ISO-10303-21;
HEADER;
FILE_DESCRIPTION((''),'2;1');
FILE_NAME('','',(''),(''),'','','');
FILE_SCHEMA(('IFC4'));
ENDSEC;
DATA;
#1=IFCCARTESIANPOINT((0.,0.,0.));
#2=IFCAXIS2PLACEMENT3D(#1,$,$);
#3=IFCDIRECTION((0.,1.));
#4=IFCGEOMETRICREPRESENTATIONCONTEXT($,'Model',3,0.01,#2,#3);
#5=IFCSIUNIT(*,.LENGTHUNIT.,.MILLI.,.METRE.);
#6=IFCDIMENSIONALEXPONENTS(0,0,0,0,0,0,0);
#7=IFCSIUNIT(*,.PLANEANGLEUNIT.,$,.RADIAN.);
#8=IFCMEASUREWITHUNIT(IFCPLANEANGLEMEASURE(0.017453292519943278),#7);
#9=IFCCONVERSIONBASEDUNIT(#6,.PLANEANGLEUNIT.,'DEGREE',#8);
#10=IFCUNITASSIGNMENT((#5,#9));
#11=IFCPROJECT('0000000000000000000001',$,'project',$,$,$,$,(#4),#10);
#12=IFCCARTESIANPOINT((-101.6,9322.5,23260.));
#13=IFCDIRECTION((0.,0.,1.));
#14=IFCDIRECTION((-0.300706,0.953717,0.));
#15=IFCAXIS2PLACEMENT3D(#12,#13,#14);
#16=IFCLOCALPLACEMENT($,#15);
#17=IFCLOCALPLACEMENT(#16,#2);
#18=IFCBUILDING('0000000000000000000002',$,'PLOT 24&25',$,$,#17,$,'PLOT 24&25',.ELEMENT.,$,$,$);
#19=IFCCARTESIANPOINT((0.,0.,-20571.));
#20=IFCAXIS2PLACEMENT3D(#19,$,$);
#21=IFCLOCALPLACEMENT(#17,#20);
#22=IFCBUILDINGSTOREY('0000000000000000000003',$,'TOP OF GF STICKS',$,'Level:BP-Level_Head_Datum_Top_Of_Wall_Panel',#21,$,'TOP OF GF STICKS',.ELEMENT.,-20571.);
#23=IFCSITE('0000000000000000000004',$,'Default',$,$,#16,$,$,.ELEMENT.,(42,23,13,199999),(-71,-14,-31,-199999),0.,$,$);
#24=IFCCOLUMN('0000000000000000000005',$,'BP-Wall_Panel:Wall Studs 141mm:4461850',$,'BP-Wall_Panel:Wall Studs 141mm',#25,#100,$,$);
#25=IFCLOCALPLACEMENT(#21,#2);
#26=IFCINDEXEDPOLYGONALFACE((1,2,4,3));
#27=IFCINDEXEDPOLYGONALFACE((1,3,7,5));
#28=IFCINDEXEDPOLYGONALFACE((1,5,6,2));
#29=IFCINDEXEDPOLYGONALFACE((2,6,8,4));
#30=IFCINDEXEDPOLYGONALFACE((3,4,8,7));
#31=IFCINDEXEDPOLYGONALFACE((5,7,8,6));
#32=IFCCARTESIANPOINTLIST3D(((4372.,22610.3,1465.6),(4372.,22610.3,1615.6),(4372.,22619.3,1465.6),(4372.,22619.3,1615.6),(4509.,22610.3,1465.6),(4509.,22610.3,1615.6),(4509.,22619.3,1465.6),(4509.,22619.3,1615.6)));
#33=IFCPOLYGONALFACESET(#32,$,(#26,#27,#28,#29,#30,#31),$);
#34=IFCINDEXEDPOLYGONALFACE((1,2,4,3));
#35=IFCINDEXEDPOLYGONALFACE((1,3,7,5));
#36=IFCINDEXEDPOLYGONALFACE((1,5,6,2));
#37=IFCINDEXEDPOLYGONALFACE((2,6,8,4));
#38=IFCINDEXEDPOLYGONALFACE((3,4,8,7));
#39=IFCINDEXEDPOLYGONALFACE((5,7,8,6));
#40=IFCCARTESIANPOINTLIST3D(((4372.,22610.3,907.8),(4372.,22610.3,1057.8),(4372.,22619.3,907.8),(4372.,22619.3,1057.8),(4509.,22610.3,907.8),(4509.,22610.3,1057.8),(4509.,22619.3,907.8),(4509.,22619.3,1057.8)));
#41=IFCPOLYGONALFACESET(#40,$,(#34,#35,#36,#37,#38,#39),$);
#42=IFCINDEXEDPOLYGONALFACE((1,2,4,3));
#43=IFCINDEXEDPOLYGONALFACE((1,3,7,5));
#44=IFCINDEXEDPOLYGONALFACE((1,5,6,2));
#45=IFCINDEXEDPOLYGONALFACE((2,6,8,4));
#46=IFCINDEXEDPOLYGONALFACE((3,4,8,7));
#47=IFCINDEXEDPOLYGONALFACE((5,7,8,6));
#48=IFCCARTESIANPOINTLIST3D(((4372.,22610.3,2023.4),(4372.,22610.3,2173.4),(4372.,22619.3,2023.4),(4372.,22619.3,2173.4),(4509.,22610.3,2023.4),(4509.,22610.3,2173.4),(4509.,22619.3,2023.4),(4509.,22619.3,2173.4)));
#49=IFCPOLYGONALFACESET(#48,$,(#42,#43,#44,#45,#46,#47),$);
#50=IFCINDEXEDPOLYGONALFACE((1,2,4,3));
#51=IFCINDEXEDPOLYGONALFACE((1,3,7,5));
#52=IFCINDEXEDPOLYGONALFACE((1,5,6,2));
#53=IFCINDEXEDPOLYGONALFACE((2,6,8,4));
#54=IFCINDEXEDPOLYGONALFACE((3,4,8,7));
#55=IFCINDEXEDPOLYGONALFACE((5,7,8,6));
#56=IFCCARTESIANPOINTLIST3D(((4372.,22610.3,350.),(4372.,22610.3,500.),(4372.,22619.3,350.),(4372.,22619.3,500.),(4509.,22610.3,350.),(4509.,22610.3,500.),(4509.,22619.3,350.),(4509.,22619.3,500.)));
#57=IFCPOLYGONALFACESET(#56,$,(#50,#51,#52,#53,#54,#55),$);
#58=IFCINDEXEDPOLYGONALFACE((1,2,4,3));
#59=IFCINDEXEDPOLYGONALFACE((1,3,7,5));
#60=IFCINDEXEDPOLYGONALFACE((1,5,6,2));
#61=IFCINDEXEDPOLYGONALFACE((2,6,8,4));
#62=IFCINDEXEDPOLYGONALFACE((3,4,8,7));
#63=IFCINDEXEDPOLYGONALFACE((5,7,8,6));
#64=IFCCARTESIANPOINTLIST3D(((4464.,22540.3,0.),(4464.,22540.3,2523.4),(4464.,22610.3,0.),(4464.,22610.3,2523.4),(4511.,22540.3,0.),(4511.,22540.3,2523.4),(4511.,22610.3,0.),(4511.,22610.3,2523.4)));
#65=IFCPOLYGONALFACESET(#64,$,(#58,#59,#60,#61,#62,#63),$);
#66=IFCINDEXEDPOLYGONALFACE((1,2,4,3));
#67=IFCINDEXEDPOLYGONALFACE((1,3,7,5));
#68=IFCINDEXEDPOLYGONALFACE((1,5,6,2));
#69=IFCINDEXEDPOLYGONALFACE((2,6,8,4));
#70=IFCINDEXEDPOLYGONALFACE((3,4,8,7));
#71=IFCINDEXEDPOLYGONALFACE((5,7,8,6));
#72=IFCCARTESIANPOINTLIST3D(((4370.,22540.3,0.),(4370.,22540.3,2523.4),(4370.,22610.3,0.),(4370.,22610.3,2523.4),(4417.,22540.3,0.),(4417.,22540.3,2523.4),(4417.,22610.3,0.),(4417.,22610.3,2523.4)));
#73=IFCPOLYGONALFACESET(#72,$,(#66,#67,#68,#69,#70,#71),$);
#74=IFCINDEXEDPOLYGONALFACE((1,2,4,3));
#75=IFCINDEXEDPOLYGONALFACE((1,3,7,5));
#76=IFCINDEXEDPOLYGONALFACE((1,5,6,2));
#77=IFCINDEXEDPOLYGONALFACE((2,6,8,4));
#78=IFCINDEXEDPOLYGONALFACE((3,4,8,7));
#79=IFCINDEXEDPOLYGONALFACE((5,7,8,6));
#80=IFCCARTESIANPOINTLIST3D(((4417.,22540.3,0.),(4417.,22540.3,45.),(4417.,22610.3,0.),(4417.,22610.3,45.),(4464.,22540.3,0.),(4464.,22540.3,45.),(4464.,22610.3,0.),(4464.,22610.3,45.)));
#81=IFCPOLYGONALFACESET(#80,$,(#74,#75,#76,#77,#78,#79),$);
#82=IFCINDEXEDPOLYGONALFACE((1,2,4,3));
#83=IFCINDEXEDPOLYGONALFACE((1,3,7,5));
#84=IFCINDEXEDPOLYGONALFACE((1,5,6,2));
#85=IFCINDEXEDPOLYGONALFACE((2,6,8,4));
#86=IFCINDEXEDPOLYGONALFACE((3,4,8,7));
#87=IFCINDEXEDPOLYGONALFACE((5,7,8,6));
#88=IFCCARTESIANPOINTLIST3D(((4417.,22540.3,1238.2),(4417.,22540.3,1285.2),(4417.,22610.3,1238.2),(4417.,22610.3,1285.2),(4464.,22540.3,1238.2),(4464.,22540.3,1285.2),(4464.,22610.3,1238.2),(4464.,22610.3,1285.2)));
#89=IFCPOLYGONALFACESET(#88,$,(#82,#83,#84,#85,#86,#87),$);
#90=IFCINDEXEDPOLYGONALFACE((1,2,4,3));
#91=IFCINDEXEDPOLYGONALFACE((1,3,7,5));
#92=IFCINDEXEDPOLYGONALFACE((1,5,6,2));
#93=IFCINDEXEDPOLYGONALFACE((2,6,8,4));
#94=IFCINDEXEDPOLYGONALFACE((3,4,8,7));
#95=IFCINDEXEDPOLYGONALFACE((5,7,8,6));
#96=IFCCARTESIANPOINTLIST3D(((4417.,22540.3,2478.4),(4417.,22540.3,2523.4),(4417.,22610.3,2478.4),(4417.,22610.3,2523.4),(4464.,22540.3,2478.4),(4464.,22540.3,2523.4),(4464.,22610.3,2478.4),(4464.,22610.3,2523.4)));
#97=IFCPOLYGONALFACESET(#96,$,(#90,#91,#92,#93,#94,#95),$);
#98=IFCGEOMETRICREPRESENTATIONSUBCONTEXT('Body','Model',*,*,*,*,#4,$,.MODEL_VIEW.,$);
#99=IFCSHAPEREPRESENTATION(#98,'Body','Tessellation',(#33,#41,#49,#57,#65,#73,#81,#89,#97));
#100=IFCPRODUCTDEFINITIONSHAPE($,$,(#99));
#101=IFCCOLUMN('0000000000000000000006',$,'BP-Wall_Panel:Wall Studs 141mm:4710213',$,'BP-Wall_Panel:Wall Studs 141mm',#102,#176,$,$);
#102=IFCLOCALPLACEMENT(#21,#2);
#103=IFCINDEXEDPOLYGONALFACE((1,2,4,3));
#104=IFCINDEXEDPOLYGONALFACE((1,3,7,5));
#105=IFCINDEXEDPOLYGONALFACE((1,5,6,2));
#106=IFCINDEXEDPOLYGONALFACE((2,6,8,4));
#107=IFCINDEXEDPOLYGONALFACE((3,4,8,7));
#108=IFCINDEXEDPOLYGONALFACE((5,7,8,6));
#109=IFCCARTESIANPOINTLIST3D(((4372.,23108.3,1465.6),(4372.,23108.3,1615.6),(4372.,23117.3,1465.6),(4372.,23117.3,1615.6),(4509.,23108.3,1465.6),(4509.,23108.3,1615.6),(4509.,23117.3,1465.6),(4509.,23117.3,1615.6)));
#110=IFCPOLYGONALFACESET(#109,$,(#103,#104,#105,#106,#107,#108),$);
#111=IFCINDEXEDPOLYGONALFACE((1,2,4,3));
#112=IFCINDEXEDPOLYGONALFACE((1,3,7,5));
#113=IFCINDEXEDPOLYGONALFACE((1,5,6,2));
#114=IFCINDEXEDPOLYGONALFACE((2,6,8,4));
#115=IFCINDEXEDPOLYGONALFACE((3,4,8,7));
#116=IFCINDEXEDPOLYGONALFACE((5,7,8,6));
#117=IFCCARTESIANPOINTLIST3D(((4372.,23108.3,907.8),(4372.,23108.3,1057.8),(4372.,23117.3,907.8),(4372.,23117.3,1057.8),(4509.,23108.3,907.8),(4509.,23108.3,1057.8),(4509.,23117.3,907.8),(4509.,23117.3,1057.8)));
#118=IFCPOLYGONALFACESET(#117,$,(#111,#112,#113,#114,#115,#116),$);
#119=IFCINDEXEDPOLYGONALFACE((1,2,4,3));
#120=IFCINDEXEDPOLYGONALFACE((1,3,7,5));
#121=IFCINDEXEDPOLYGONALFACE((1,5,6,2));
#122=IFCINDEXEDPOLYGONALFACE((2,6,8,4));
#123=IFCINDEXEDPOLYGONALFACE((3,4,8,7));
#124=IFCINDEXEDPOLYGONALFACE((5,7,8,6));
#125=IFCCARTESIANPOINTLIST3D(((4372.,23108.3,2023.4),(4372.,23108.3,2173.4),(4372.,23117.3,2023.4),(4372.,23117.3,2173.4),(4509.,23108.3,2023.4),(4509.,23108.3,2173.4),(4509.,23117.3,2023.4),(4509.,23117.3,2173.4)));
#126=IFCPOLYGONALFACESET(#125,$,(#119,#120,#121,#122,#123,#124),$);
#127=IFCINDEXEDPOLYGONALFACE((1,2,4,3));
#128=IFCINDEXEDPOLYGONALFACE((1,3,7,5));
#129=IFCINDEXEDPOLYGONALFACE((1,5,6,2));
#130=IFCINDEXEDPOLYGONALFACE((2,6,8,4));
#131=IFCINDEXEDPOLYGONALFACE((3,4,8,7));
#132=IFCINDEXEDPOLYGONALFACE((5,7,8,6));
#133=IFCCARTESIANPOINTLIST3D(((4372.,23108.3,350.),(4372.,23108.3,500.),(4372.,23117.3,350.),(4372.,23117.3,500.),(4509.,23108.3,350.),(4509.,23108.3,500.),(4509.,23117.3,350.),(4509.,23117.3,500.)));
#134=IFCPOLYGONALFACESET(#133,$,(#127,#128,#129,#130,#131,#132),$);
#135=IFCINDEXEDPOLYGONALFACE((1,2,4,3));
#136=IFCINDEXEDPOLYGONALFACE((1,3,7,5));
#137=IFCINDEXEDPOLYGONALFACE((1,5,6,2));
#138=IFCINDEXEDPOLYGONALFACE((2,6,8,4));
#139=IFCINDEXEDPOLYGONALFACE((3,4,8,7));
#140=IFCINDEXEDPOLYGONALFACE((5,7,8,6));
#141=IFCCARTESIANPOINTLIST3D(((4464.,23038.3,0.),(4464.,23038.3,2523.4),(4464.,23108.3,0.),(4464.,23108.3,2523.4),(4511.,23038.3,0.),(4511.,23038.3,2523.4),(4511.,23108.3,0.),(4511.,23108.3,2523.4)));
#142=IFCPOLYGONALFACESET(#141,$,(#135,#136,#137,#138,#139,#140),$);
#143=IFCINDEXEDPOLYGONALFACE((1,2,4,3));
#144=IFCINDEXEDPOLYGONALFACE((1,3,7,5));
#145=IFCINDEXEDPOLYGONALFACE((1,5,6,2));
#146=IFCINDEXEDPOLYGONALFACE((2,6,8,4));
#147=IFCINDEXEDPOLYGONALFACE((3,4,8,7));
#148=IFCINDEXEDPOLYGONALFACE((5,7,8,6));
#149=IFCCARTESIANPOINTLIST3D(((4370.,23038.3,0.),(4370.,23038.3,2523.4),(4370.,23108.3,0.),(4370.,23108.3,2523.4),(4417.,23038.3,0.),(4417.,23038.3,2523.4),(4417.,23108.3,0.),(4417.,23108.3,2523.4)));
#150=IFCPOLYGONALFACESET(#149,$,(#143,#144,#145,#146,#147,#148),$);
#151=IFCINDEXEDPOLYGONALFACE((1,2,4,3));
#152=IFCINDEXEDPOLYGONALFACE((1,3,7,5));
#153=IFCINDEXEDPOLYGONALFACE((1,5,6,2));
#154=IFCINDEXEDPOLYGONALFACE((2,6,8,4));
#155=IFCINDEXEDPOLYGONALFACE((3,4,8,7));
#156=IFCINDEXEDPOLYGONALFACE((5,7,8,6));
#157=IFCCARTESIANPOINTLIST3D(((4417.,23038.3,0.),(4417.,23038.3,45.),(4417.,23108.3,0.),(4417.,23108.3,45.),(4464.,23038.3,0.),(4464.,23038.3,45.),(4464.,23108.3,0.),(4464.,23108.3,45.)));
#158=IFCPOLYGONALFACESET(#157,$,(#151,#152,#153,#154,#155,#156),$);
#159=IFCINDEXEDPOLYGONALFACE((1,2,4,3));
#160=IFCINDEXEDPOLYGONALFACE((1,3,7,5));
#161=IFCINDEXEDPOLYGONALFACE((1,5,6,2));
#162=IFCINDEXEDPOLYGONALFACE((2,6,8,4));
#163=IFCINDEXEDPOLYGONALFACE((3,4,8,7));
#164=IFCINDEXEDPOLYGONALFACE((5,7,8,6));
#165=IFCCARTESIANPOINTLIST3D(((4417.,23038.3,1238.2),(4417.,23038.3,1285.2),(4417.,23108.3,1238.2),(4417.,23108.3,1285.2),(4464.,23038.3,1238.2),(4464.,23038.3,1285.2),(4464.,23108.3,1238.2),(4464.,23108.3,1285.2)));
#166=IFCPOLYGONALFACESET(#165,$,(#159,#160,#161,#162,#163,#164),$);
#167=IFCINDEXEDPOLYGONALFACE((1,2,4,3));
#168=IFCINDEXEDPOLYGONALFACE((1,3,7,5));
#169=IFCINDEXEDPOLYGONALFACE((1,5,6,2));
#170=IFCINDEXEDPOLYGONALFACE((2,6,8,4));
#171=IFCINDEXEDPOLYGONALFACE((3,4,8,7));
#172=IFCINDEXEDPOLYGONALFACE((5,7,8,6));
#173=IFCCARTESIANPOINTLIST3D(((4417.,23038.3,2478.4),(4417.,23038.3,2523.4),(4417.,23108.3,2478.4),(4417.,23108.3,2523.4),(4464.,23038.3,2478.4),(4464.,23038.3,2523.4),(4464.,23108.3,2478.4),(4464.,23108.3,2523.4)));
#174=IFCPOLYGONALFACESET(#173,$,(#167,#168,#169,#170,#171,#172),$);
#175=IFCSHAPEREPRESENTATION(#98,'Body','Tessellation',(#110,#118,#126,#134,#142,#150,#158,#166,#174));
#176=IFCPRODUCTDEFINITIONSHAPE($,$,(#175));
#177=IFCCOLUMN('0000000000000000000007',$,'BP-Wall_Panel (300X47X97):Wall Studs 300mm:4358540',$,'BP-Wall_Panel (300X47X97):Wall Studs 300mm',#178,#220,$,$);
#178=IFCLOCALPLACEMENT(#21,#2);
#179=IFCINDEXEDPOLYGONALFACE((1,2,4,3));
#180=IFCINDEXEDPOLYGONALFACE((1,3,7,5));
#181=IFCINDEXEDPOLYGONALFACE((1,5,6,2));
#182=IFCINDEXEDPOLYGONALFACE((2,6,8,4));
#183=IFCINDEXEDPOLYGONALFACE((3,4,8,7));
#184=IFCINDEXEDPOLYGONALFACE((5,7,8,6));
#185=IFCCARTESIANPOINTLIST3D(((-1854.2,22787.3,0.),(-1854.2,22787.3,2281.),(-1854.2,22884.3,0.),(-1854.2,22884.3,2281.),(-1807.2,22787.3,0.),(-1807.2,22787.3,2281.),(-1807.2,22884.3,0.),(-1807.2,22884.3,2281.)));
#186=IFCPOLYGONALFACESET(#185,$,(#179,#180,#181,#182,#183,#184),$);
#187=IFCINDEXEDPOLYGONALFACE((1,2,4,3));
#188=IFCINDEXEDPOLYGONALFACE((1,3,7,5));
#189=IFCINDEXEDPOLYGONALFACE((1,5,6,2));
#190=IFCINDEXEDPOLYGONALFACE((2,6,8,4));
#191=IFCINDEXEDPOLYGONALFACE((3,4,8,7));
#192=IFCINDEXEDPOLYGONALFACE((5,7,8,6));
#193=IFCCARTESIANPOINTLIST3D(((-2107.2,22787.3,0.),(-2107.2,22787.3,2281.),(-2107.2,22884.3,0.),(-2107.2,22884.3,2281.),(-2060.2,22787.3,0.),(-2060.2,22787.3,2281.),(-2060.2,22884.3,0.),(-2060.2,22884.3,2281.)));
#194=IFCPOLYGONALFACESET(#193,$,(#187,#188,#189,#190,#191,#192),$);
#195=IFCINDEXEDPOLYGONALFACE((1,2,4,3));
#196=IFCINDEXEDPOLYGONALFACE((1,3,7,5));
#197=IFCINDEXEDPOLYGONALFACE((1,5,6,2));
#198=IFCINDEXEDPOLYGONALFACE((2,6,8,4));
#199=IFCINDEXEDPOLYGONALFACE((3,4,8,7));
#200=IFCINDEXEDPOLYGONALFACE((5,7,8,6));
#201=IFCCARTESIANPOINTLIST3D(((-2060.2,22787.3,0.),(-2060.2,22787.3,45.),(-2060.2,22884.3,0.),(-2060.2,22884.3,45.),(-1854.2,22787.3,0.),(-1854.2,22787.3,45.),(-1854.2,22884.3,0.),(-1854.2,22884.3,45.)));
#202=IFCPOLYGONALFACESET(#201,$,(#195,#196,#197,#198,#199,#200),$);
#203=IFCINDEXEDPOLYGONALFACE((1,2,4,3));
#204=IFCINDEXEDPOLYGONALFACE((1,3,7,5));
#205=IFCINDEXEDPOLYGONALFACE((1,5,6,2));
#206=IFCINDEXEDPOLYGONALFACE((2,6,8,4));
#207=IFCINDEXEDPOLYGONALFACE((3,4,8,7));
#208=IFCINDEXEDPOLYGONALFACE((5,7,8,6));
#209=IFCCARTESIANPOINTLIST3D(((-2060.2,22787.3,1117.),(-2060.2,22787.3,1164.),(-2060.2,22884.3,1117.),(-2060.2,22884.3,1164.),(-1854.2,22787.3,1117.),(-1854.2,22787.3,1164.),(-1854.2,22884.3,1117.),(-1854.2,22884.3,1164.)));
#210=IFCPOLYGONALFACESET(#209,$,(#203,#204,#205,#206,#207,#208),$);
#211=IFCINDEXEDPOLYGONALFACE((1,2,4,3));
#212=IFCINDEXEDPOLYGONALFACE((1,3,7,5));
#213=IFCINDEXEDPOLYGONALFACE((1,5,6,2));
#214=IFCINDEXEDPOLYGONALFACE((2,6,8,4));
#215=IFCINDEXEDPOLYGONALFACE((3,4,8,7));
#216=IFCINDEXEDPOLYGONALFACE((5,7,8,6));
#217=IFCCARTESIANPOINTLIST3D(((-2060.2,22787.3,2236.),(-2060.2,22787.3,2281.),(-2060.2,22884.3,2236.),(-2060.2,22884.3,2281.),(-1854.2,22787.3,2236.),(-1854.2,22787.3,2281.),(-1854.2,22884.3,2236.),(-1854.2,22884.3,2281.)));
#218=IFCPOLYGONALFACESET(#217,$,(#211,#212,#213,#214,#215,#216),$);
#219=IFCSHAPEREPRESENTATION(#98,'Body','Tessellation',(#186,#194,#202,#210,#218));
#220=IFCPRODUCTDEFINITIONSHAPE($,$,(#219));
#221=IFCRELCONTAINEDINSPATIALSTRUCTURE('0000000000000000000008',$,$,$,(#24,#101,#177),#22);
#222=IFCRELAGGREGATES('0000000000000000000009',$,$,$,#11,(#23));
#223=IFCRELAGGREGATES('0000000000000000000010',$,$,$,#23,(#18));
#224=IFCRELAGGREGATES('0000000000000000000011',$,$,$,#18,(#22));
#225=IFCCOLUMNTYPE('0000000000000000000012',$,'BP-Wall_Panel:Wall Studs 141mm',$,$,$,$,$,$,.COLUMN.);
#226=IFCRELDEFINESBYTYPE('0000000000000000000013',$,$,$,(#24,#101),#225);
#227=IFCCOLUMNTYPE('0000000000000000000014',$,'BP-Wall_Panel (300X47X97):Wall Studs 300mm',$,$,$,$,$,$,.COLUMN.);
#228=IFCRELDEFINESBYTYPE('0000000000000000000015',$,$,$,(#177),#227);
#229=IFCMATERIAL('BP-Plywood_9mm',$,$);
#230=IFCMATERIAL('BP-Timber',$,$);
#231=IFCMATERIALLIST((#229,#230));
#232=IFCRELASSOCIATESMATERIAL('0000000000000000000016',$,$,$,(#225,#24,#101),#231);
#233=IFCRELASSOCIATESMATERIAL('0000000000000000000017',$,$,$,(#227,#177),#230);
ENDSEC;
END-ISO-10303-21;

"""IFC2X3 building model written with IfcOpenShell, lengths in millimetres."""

from ifc_helpers import new_model, entity, si_unit, converted_unit, direction, frame, frame_2d, origin, origin_2d_with_axis, place, context, subcontext, project, spatial, rectangle, extrude, source, transform, mapped, material, material_list, type_object, type_shapes, element, save


model = new_model("IFC2X3")

# Units and contexts
model_context = context("Model", 3, precision=0.01, world=origin(), true_north=direction((0.0, 1.0)))
body_context = subcontext(model_context, "Body", "Model", "MODEL_VIEW")
ifc_project = project(units=[si_unit("LENGTHUNIT", "METRE", prefix="MILLI"), converted_unit("PLANEANGLEUNIT", "DEGREE", entity("IfcPlaneAngleMeasure", 0.017453292519943278), si_unit("PLANEANGLEUNIT", "RADIAN"), dimensions=[0, 0, 0, 0, 0, 0, 0])], contexts=[model_context])

# Site, building, storey
site_placement = place(None, frame((-101.6, 9322.5, 23260.0), z_axis=(0.0, 0.0, 1.0), x_axis=(-0.300706, 0.953717, 0.0)))
site = spatial("IfcSite", under=ifc_project, at=site_placement, Name="Default", CompositionType="ELEMENT", RefLatitude=(42, 23, 13, 199999), RefLongitude=(-71, -14, -31, -199999), RefElevation=0.0)
building_placement = place(site_placement, origin())
building = spatial("IfcBuilding", under=site, at=building_placement, Name="PLOT 24&25", LongName="PLOT 24&25", CompositionType="ELEMENT")
storey_placement = place(building_placement, frame((0.0, 0.0, -20571.0)))
storey = spatial("IfcBuildingStorey", under=building, at=storey_placement, Name="TOP OF GF STICKS", ObjectType="Level:BP-Level_Head_Datum_Top_Of_Wall_Panel", LongName="TOP OF GF STICKS", CompositionType="ELEMENT", Elevation=-20571.0)

# Columns
ifc_material_1 = material(Name="BP-Plywood_9mm")
ifc_material_2 = material(Name="BP-Timber")
ifc_material_list = material_list([ifc_material_1, ifc_material_2])
column_type_1 = type_object("IfcColumnType", Name="BP-Wall_Panel:Wall Studs 141mm", PredefinedType="COLUMN", material=ifc_material_list)
shared_shape_1 = source(origin(), body_context, "Body", "SweptSolid", [
    extrude(rectangle(XDim=137.0, YDim=9.0, at=origin_2d_with_axis()), frame((39.5, 0.0, -19105.4), z_axis=(0.0, 0.0, 1.0), x_axis=(0.0, -1.0, 0.0)), (0.0, 0.0, 1.0), 150.0),
    extrude(rectangle(XDim=137.0, YDim=9.0, at=origin_2d_with_axis()), frame((39.5, 0.0, -19663.2), z_axis=(0.0, 0.0, 1.0), x_axis=(0.0, -1.0, 0.0)), (0.0, 0.0, 1.0), 150.0),
    extrude(rectangle(XDim=137.0, YDim=9.0, at=frame_2d((0.0, 0.0), x_axis=(1.0, 0.0))), frame((39.5, 0.0, -18547.6), z_axis=(0.0, 0.0, 1.0), x_axis=(0.0, -1.0, 0.0)), (0.0, 0.0, 1.0), 150.0),
    extrude(rectangle(XDim=137.0, YDim=9.0, at=origin_2d_with_axis()), frame((39.5, 0.0, -20221.0), z_axis=(0.0, 0.0, 1.0), x_axis=(0.0, -1.0, 0.0)), (0.0, 0.0, 1.0), 150.0),
    extrude(rectangle(XDim=70.0, YDim=47.0, at=origin_2d_with_axis()), frame((0.0, -47.0, -20571.0), z_axis=(0.0, 0.0, 1.0), x_axis=(-1.0, 0.0, 0.0)), (0.0, 0.0, 1.0), 2523.4),
    extrude(rectangle(XDim=70.0, YDim=47.0, at=origin_2d_with_axis()), frame((0.0, 47.0, -20571.0), z_axis=(0.0, 0.0, 1.0), x_axis=(-1.0, 0.0, 0.0)), (0.0, 0.0, 1.0), 2523.4),
    extrude(rectangle(XDim=47.0, YDim=70.0, at=origin_2d_with_axis()), frame((0.0, 0.0, -20571.0), z_axis=(0.0, 0.0, 1.0), x_axis=(0.0, -1.0, 0.0)), (0.0, 0.0, 1.0), 45.0),
    extrude(rectangle(XDim=47.0, YDim=70.0, at=origin_2d_with_axis()), frame((0.0, 0.0, -19332.8), z_axis=(0.0, 0.0, 1.0), x_axis=(0.0, -1.0, 0.0)), (0.0, 0.0, 1.0), 47.0),
    extrude(rectangle(XDim=47.0, YDim=70.0, at=origin_2d_with_axis()), frame((0.0, 0.0, -18092.6), z_axis=(0.0, 0.0, 1.0), x_axis=(0.0, -1.0, 0.0)), (0.0, 0.0, 1.0), 45.0),
])
type_shapes(column_type_1, [shared_shape_1])
for number, where, z_axis, x_axis, name in (
    (1, (4440.5, 22575.3, 20571.0), (0.0, 0.0, 1.0), (0.0, 1.0, 0.0), "BP-Wall_Panel:Wall Studs 141mm:4461850"),
    (2, (4440.5, 23073.3, 20571.0), (0.0, 0.0, 1.0), (0.0, 1.0, 0.0), "BP-Wall_Panel:Wall Studs 141mm:4710213"),
):
    element("IfcColumn", number, at=place(storey_placement, frame(where, z_axis=z_axis, x_axis=x_axis)), inside=storey, type_object=column_type_1, material=ifc_material_list, Name=name, ObjectType="BP-Wall_Panel:Wall Studs 141mm", context=body_context, shape_type="MappedRepresentation", body=[
        mapped(shared_shape_1, transform((0.0, 0.0, 0.0), scale=1.0)),
    ])
column_type_2 = type_object("IfcColumnType", Name="BP-Wall_Panel (300X47X97):Wall Studs 300mm", PredefinedType="COLUMN", material=ifc_material_2)
shared_shape_2 = source(origin(), body_context, "Body", "SweptSolid", [
    extrude(rectangle(XDim=97.0, YDim=47.0, at=origin_2d_with_axis()), frame((0.0, -126.5, -20571.0), z_axis=(0.0, 0.0, 1.0), x_axis=(-1.0, 0.0, 0.0)), (0.0, 0.0, 1.0), 2281.0),
    extrude(rectangle(XDim=97.0, YDim=47.0, at=frame_2d((0.0, 0.0), x_axis=(1.0, 0.0))), frame((0.0, 126.5, -20571.0), z_axis=(0.0, 0.0, 1.0), x_axis=(-1.0, 0.0, 0.0)), (0.0, 0.0, 1.0), 2281.0),
    extrude(rectangle(XDim=206.0, YDim=97.0, at=origin_2d_with_axis()), frame((0.0, 0.0, -20571.0), z_axis=(0.0, 0.0, 1.0), x_axis=(0.0, -1.0, 0.0)), (0.0, 0.0, 1.0), 45.0),
    extrude(rectangle(XDim=206.0, YDim=97.0, at=origin_2d_with_axis()), frame((0.0, 0.0, -19454.0), z_axis=(0.0, 0.0, 1.0), x_axis=(0.0, -1.0, 0.0)), (0.0, 0.0, 1.0), 47.0),
    extrude(rectangle(XDim=206.0, YDim=97.0, at=origin_2d_with_axis()), frame((0.0, 0.0, -18335.0), z_axis=(0.0, 0.0, 1.0), x_axis=(0.0, -1.0, 0.0)), (0.0, 0.0, 1.0), 45.0),
])
type_shapes(column_type_2, [shared_shape_2])
for number, where, z_axis, x_axis, name in (
    (3, (-1957.2, 22835.8, 20571.0), (0.0, 0.0, 1.0), (0.0, 1.0, 0.0), "BP-Wall_Panel (300X47X97):Wall Studs 300mm:4358540"),
):
    element("IfcColumn", number, at=place(storey_placement, frame(where, z_axis=z_axis, x_axis=x_axis)), inside=storey, type_object=column_type_2, material=ifc_material_2, Name=name, ObjectType="BP-Wall_Panel (300X47X97):Wall Studs 300mm", context=body_context, shape_type="MappedRepresentation", body=[
        mapped(shared_shape_2, transform((0.0, 0.0, 0.0), scale=1.0)),
    ])

save(model, "model.ifc")
